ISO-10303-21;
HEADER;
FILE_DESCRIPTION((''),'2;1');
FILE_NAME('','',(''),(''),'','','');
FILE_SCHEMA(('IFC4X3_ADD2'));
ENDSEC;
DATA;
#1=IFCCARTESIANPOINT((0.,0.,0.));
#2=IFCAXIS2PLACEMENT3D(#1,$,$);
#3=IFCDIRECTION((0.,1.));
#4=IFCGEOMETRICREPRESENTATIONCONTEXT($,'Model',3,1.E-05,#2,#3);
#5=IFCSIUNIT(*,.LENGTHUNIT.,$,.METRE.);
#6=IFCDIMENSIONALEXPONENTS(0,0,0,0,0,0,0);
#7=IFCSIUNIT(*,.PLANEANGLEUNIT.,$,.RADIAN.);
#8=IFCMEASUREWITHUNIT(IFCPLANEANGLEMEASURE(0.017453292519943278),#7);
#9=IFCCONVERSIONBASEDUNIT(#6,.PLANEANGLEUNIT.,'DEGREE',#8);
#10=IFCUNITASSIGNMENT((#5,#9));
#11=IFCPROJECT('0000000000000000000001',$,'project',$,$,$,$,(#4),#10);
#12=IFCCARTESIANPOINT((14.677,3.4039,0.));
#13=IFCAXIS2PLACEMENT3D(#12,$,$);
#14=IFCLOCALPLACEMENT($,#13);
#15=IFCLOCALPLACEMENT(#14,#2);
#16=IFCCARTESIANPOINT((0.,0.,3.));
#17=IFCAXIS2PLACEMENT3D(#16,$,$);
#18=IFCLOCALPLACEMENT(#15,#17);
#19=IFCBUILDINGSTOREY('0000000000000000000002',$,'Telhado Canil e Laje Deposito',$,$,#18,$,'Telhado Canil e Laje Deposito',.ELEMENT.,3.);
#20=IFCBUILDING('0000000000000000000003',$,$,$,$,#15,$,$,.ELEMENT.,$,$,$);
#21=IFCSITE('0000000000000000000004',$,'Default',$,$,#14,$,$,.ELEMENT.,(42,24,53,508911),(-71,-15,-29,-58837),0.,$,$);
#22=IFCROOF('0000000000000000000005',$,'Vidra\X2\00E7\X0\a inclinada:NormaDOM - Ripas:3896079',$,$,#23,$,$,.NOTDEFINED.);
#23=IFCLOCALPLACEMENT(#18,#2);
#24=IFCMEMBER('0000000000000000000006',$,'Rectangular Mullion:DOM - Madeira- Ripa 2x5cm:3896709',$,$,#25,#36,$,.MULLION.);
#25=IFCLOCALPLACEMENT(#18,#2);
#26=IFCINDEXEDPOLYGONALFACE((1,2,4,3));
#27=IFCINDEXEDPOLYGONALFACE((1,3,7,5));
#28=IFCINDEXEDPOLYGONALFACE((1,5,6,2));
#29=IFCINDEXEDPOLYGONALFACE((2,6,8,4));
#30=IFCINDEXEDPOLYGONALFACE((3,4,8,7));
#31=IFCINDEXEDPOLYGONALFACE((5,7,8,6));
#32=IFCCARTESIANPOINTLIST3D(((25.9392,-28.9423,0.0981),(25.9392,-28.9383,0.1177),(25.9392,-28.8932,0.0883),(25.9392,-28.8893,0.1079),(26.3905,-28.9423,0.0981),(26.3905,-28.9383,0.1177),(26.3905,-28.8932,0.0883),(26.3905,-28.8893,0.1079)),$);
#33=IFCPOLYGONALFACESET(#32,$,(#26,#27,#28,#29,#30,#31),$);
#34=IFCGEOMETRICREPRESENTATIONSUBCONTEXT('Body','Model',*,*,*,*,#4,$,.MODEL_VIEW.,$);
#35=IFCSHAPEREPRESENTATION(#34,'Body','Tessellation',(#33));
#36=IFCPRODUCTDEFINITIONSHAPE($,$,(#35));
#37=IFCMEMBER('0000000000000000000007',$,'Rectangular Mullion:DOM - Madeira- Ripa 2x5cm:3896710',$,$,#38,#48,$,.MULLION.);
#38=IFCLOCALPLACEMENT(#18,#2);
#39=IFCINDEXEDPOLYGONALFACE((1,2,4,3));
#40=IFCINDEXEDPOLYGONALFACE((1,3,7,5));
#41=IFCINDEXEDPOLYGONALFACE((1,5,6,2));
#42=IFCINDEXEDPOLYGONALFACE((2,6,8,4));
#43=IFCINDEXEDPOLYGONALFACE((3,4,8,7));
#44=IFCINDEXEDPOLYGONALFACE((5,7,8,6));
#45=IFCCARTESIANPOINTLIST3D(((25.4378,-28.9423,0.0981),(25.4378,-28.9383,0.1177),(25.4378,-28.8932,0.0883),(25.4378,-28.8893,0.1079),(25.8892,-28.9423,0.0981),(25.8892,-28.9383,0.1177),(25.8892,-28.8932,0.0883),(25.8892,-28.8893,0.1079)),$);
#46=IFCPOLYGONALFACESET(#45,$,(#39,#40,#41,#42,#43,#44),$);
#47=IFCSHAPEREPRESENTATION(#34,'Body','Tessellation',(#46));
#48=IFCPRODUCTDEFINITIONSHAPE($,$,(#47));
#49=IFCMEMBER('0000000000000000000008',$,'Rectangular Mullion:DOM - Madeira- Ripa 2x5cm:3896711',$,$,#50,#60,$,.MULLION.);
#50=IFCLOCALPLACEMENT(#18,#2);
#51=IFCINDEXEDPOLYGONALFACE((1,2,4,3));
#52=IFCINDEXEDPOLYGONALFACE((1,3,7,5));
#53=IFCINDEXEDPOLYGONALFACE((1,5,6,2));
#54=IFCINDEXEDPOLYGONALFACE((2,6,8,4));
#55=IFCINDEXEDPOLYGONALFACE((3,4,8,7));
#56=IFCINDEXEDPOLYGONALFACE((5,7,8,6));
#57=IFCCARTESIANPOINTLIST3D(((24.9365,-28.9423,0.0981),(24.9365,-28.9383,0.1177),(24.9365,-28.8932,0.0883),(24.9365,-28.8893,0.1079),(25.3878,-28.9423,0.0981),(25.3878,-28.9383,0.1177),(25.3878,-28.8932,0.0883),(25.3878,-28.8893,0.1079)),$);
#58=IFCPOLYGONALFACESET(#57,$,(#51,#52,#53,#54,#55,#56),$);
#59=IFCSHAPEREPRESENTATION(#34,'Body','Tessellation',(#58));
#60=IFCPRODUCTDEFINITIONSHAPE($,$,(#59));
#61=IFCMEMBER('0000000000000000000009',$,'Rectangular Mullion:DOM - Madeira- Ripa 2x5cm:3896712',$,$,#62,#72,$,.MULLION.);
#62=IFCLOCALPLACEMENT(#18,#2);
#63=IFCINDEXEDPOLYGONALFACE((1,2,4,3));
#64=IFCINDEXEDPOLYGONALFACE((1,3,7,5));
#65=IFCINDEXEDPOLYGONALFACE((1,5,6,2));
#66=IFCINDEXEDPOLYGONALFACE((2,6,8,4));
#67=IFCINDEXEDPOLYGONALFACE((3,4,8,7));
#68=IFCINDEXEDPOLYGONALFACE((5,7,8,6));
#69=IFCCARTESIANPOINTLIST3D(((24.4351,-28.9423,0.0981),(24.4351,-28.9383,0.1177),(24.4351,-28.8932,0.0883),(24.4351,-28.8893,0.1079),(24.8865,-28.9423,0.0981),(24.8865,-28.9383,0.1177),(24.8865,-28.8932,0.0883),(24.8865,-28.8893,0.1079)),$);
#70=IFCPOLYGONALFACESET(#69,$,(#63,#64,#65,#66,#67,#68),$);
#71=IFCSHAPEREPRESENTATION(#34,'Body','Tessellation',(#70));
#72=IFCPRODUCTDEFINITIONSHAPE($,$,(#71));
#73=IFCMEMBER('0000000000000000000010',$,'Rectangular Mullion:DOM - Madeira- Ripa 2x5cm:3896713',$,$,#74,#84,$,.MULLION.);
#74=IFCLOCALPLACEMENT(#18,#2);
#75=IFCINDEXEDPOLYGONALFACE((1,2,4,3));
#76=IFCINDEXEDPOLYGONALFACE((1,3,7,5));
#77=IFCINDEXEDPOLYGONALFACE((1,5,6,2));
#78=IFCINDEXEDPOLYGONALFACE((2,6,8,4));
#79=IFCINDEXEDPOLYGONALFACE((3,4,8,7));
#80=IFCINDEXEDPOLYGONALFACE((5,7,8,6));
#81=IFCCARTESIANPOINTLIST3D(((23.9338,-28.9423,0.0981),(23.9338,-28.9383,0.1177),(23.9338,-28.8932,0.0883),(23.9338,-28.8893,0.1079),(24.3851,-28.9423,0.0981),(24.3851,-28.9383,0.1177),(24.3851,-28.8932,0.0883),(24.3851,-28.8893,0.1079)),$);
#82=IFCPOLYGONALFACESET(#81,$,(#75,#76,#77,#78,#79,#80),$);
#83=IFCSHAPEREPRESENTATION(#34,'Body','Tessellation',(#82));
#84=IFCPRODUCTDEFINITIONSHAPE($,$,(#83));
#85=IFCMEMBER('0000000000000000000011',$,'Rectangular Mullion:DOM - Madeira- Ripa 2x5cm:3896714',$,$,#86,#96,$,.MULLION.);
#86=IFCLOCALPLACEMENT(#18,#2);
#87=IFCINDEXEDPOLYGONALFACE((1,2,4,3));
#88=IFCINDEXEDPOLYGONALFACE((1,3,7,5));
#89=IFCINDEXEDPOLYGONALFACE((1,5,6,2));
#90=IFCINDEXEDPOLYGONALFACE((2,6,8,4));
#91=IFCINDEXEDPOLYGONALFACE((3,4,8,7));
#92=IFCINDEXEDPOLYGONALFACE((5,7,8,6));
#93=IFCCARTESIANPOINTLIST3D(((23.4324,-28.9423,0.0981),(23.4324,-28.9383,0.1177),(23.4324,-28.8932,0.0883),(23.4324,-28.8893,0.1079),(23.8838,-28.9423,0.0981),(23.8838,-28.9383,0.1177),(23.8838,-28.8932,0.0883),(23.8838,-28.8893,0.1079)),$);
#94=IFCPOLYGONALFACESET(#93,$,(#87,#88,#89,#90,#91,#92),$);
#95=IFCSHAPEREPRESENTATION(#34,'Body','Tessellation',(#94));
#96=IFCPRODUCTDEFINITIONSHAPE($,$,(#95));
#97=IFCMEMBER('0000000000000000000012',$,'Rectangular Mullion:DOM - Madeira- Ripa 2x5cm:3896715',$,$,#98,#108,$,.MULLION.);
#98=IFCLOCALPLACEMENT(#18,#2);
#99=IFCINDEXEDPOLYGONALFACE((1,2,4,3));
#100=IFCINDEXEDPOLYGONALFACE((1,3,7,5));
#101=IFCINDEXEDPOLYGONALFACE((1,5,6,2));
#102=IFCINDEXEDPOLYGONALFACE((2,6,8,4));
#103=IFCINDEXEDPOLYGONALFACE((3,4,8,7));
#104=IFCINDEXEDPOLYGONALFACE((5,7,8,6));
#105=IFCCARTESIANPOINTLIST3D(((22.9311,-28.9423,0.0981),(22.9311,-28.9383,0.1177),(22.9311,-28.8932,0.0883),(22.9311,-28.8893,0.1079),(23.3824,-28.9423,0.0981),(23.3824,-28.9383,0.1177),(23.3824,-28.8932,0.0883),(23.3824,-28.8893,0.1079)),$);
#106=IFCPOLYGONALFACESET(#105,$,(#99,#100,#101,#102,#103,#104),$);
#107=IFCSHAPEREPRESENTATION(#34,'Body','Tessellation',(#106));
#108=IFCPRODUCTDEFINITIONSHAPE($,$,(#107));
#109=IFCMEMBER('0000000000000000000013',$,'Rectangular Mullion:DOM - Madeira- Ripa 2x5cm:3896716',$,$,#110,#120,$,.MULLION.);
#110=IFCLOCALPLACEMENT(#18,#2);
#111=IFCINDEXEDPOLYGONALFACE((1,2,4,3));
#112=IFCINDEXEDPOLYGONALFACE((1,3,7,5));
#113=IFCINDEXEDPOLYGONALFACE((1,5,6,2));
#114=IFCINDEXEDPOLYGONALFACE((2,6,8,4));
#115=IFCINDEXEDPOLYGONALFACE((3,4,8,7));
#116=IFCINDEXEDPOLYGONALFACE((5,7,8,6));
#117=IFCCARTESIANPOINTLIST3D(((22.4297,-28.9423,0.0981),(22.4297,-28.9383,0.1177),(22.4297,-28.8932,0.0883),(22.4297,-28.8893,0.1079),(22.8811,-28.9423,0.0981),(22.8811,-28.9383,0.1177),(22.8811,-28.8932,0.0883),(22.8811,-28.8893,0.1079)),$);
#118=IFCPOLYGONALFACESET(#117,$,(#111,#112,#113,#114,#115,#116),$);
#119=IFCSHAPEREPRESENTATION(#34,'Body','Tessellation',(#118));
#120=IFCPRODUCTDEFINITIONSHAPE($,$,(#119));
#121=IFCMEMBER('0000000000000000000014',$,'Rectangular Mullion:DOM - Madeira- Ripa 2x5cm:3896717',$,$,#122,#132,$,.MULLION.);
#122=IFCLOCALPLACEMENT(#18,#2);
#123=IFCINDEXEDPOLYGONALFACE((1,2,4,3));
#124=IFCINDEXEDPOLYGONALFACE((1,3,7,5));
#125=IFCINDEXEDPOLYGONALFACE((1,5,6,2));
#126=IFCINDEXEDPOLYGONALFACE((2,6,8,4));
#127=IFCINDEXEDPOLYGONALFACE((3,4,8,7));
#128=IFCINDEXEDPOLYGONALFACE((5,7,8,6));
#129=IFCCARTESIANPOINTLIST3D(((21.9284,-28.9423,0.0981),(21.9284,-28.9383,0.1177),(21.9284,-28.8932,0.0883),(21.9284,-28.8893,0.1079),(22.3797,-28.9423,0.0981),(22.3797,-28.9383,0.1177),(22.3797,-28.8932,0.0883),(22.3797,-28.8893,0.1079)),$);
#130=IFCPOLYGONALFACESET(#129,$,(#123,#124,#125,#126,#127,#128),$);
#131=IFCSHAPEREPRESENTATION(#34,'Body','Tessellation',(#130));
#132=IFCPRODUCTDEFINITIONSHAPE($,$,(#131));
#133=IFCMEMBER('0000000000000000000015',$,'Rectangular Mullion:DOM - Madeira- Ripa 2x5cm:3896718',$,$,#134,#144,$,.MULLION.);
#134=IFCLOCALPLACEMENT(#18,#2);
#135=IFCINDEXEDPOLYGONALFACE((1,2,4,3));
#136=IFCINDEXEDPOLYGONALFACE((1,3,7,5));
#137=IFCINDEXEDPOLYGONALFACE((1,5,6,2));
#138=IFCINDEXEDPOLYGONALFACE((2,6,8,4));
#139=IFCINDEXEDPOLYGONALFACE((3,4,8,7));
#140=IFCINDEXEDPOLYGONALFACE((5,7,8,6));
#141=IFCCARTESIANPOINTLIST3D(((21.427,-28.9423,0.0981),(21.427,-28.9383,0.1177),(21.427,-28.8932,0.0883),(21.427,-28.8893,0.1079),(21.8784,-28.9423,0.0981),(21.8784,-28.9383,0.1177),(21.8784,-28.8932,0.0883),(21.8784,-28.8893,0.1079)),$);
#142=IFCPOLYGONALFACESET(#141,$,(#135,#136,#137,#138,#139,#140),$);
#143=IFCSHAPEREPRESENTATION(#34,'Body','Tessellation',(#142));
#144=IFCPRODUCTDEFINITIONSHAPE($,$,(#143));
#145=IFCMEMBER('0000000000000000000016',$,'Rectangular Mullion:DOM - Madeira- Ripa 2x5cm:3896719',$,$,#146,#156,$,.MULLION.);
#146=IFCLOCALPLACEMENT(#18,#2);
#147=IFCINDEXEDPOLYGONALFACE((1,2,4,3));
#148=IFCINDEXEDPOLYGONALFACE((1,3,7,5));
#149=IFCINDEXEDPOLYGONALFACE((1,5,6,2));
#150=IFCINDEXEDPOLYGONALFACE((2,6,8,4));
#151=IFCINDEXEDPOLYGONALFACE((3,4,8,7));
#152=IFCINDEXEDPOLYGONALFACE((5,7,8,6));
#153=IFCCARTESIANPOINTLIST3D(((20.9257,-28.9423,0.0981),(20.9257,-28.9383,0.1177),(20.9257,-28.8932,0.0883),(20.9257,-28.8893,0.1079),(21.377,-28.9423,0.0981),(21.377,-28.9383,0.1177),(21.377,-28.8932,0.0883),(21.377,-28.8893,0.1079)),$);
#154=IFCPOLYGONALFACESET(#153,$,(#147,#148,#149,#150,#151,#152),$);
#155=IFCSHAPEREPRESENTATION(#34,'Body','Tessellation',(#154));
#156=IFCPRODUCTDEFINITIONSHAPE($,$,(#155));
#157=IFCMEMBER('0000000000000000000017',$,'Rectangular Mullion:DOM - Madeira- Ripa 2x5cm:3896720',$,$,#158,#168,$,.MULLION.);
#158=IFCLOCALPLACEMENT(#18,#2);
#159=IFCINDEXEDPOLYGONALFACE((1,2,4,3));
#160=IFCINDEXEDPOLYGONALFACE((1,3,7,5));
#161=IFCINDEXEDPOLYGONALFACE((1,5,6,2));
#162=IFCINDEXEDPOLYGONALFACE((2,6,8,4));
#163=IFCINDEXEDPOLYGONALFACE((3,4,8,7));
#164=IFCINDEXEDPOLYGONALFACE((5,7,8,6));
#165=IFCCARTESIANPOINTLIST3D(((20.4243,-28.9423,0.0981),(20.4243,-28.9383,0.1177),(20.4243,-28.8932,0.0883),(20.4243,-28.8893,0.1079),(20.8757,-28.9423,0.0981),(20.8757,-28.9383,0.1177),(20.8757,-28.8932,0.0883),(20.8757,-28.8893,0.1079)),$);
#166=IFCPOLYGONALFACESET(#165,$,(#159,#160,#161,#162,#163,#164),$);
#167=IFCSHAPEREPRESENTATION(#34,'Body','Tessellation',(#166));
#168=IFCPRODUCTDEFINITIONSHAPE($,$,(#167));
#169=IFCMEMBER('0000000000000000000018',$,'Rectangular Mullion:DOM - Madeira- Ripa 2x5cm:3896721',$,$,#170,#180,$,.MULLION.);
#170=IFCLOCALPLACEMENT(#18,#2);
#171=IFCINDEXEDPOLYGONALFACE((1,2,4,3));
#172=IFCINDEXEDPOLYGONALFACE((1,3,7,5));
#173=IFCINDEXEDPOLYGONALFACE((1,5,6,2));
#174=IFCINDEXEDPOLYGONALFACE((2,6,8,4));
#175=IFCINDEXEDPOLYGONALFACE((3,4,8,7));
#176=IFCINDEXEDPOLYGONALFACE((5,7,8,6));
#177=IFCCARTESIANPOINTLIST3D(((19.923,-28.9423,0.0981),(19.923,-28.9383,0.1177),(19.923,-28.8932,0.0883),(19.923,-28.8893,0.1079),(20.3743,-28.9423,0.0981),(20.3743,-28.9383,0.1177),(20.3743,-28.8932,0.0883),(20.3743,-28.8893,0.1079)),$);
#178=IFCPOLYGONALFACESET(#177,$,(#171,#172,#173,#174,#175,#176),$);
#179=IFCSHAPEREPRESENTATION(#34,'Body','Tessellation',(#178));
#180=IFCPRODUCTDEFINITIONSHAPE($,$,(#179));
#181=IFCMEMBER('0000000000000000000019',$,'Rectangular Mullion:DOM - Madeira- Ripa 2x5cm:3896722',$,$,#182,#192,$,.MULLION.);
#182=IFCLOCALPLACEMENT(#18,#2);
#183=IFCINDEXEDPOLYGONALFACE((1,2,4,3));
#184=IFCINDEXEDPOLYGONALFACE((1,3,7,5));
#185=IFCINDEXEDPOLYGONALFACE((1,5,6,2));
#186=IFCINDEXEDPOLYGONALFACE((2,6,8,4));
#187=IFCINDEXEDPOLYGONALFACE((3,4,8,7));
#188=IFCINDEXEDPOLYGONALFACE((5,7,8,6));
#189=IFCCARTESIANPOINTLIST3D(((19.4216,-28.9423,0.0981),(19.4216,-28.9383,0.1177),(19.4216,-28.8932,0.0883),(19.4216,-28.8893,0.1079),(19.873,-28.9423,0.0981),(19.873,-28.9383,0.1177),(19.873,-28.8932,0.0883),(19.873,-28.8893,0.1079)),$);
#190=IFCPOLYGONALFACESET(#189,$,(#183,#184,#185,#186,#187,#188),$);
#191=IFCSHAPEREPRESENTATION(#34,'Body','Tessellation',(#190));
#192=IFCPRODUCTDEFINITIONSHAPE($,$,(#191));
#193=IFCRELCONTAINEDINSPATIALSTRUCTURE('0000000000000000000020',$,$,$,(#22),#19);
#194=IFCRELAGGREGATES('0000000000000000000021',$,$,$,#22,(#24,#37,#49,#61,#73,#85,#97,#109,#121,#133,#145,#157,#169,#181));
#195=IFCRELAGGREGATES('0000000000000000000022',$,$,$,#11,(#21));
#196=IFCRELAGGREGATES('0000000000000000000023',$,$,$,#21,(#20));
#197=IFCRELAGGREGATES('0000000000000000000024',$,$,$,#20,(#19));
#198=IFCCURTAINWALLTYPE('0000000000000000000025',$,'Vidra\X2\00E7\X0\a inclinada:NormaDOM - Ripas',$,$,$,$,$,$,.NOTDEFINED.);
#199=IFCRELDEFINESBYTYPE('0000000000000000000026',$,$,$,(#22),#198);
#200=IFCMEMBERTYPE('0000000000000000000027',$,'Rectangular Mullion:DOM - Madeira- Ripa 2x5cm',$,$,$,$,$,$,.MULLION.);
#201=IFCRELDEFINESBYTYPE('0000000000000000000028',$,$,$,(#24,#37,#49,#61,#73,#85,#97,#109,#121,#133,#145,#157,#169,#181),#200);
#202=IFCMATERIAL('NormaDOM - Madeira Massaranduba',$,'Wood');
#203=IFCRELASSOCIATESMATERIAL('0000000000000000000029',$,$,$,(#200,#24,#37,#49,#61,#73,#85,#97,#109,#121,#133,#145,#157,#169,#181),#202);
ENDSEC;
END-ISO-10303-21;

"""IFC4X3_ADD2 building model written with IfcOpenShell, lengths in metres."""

from ifc_helpers import new_model, entity, si_unit, converted_unit, direction, frame, origin, origin_2d_with_axis, place, context, subcontext, project, spatial, rectangle, extrude, source, transform, mapped, material, material_profile, profile_set, profile_usage, type_object, type_shapes, element, aggregate, save


model = new_model("IFC4X3_ADD2")

# Units and contexts
model_context = context("Model", 3, precision=1e-05, world=origin(), true_north=direction((0.0, 1.0)))
body_context = subcontext(model_context, "Body", "Model", "MODEL_VIEW")
ifc_project = project(units=[si_unit("LENGTHUNIT", "METRE"), converted_unit("PLANEANGLEUNIT", "DEGREE", entity("IfcPlaneAngleMeasure", 0.017453292519943278), si_unit("PLANEANGLEUNIT", "RADIAN"), dimensions=[0, 0, 0, 0, 0, 0, 0])], contexts=[model_context])

# Site, building, storey
site_placement = place(None, frame((14.677, 3.4039, 0.0)))
site = spatial("IfcSite", under=ifc_project, at=site_placement, Name="Default", CompositionType="ELEMENT", RefLatitude=(42, 24, 53, 508911), RefLongitude=(-71, -15, -29, -58837), RefElevation=0.0)
building_placement = place(site_placement, origin())
building = spatial("IfcBuilding", under=site, at=building_placement, CompositionType="ELEMENT")
storey_placement = place(building_placement, frame((0.0, 0.0, 3.0)))
storey = spatial("IfcBuildingStorey", under=building, at=storey_placement, Name="Telhado Canil e Laje Deposito", LongName="Telhado Canil e Laje Deposito", CompositionType="ELEMENT", Elevation=3.0)

# Roof, members
curtain_wall_type = type_object("IfcCurtainWallType", Name="Vidraça inclinada:NormaDOM - Ripas", PredefinedType="NOTDEFINED")
roof_placement = place(storey_placement, frame((0.0, 0.0, -3.0)))
roof = element("IfcRoof", 1, at=roof_placement, inside=storey, type_object=curtain_wall_type, Name="Vidraça inclinada:NormaDOM - Ripas:3896079", PredefinedType="NOTDEFINED")
ifc_material = material(Name="NormaDOM - Madeira Massaranduba", Category="Wood")
ifc_material_profile_1 = material_profile(ifc_material, rectangle(XDim=0.05, YDim=0.02, at=origin_2d_with_axis()), Name="DOM - Madeira- Ripa 2x5cm")
ifc_profile_set_1 = profile_set([ifc_material_profile_1], Name="DOM - Madeira- Ripa 2x5cm")
ifc_profile_usage_1 = profile_usage(ifc_profile_set_1)
member_type_1 = type_object("IfcMemberType", Name="Rectangular Mullion:DOM - Madeira- Ripa 2x5cm", PredefinedType="MULLION", material=ifc_profile_set_1)
shared_shape_1 = source(origin(), body_context, "Body", "SweptSolid", [
    extrude(rectangle(XDim=0.05, YDim=0.02, at=origin_2d_with_axis()), frame((0.025, 0.01, -0.4514), z_axis=(0.0, 0.0, 1.0), x_axis=(-1.0, 0.0, 0.0)), (0.0, 0.0, 1.0), 0.4514),
])
type_shapes(member_type_1, [shared_shape_1])
member_1_placement = place(roof_placement, frame((26.3905, -28.8893, 3.1079), z_axis=(1.0, 0.0, 0.0), x_axis=(0.0, -0.980581, 0.196116)))
member_1 = element("IfcMember", 2, at=member_1_placement, type_object=member_type_1, material=ifc_profile_usage_1, Name="Rectangular Mullion:DOM - Madeira- Ripa 2x5cm:3896709", PredefinedType="MULLION", context=body_context, shape_type="MappedRepresentation", body=[
    mapped(shared_shape_1, transform((0.0, 0.0, 0.0), scale=1.0)),
])
member_2_placement = place(roof_placement, frame((25.8892, -28.8893, 3.1079), z_axis=(1.0, 0.0, 0.0), x_axis=(0.0, -0.980581, 0.196116)))
member_2 = element("IfcMember", 3, at=member_2_placement, type_object=member_type_1, material=ifc_profile_usage_1, Name="Rectangular Mullion:DOM - Madeira- Ripa 2x5cm:3896710", PredefinedType="MULLION", context=body_context, shape_type="MappedRepresentation", body=[
    mapped(shared_shape_1, transform((0.0, 0.0, 0.0), scale=1.0)),
])
member_3_placement = place(roof_placement, frame((25.3878, -28.8893, 3.1079), z_axis=(1.0, 0.0, 0.0), x_axis=(0.0, -0.980581, 0.196116)))
member_3 = element("IfcMember", 4, at=member_3_placement, type_object=member_type_1, material=ifc_profile_usage_1, Name="Rectangular Mullion:DOM - Madeira- Ripa 2x5cm:3896711", PredefinedType="MULLION", context=body_context, shape_type="MappedRepresentation", body=[
    mapped(shared_shape_1, transform((0.0, 0.0, 0.0), scale=1.0)),
])
member_4_placement = place(roof_placement, frame((24.8865, -28.8893, 3.1079), z_axis=(1.0, 0.0, 0.0), x_axis=(0.0, -0.980581, 0.196116)))
member_4 = element("IfcMember", 5, at=member_4_placement, type_object=member_type_1, material=ifc_profile_usage_1, Name="Rectangular Mullion:DOM - Madeira- Ripa 2x5cm:3896712", PredefinedType="MULLION", context=body_context, shape_type="MappedRepresentation", body=[
    mapped(shared_shape_1, transform((0.0, 0.0, 0.0), scale=1.0)),
])
member_5_placement = place(roof_placement, frame((24.3851, -28.8893, 3.1079), z_axis=(1.0, 0.0, 0.0), x_axis=(0.0, -0.980581, 0.196116)))
member_5 = element("IfcMember", 6, at=member_5_placement, type_object=member_type_1, material=ifc_profile_usage_1, Name="Rectangular Mullion:DOM - Madeira- Ripa 2x5cm:3896713", PredefinedType="MULLION", context=body_context, shape_type="MappedRepresentation", body=[
    mapped(shared_shape_1, transform((0.0, 0.0, 0.0), scale=1.0)),
])
member_6_placement = place(roof_placement, frame((23.8838, -28.8893, 3.1079), z_axis=(1.0, 0.0, 0.0), x_axis=(0.0, -0.980581, 0.196116)))
member_6 = element("IfcMember", 7, at=member_6_placement, type_object=member_type_1, material=ifc_profile_usage_1, Name="Rectangular Mullion:DOM - Madeira- Ripa 2x5cm:3896714", PredefinedType="MULLION", context=body_context, shape_type="MappedRepresentation", body=[
    mapped(shared_shape_1, transform((0.0, 0.0, 0.0), scale=1.0)),
])
member_7_placement = place(roof_placement, frame((23.3824, -28.8893, 3.1079), z_axis=(1.0, 0.0, 0.0), x_axis=(0.0, -0.980581, 0.196116)))
member_7 = element("IfcMember", 8, at=member_7_placement, type_object=member_type_1, material=ifc_profile_usage_1, Name="Rectangular Mullion:DOM - Madeira- Ripa 2x5cm:3896715", PredefinedType="MULLION", context=body_context, shape_type="MappedRepresentation", body=[
    mapped(shared_shape_1, transform((0.0, 0.0, 0.0), scale=1.0)),
])
member_8_placement = place(roof_placement, frame((22.8811, -28.8893, 3.1079), z_axis=(1.0, 0.0, 0.0), x_axis=(0.0, -0.980581, 0.196116)))
member_8 = element("IfcMember", 9, at=member_8_placement, type_object=member_type_1, material=ifc_profile_usage_1, Name="Rectangular Mullion:DOM - Madeira- Ripa 2x5cm:3896716", PredefinedType="MULLION", context=body_context, shape_type="MappedRepresentation", body=[
    mapped(shared_shape_1, transform((0.0, 0.0, 0.0), scale=1.0)),
])
member_9_placement = place(roof_placement, frame((22.3797, -28.8893, 3.1079), z_axis=(1.0, 0.0, 0.0), x_axis=(0.0, -0.980581, 0.196116)))
member_9 = element("IfcMember", 10, at=member_9_placement, type_object=member_type_1, material=ifc_profile_usage_1, Name="Rectangular Mullion:DOM - Madeira- Ripa 2x5cm:3896717", PredefinedType="MULLION", context=body_context, shape_type="MappedRepresentation", body=[
    mapped(shared_shape_1, transform((0.0, 0.0, 0.0), scale=1.0)),
])
member_10_placement = place(roof_placement, frame((21.8784, -28.8893, 3.1079), z_axis=(1.0, 0.0, 0.0), x_axis=(0.0, -0.980581, 0.196116)))
member_10 = element("IfcMember", 11, at=member_10_placement, type_object=member_type_1, material=ifc_profile_usage_1, Name="Rectangular Mullion:DOM - Madeira- Ripa 2x5cm:3896718", PredefinedType="MULLION", context=body_context, shape_type="MappedRepresentation", body=[
    mapped(shared_shape_1, transform((0.0, 0.0, 0.0), scale=1.0)),
])
member_11_placement = place(roof_placement, frame((21.377, -28.8893, 3.1079), z_axis=(1.0, 0.0, 0.0), x_axis=(0.0, -0.980581, 0.196116)))
member_11 = element("IfcMember", 12, at=member_11_placement, type_object=member_type_1, material=ifc_profile_usage_1, Name="Rectangular Mullion:DOM - Madeira- Ripa 2x5cm:3896719", PredefinedType="MULLION", context=body_context, shape_type="MappedRepresentation", body=[
    mapped(shared_shape_1, transform((0.0, 0.0, 0.0), scale=1.0)),
])
member_12_placement = place(roof_placement, frame((20.8757, -28.8893, 3.1079), z_axis=(1.0, 0.0, 0.0), x_axis=(0.0, -0.980581, 0.196116)))
member_12 = element("IfcMember", 13, at=member_12_placement, type_object=member_type_1, material=ifc_profile_usage_1, Name="Rectangular Mullion:DOM - Madeira- Ripa 2x5cm:3896720", PredefinedType="MULLION", context=body_context, shape_type="MappedRepresentation", body=[
    mapped(shared_shape_1, transform((0.0, 0.0, 0.0), scale=1.0)),
])
member_13_placement = place(roof_placement, frame((20.3743, -28.8893, 3.1079), z_axis=(1.0, 0.0, 0.0), x_axis=(0.0, -0.980581, 0.196116)))
member_13 = element("IfcMember", 14, at=member_13_placement, type_object=member_type_1, material=ifc_profile_usage_1, Name="Rectangular Mullion:DOM - Madeira- Ripa 2x5cm:3896721", PredefinedType="MULLION", context=body_context, shape_type="MappedRepresentation", body=[
    mapped(shared_shape_1, transform((0.0, 0.0, 0.0), scale=1.0)),
])
member_14_placement = place(roof_placement, frame((19.873, -28.8893, 3.1079), z_axis=(1.0, 0.0, 0.0), x_axis=(0.0, -0.980581, 0.196116)))
member_14 = element("IfcMember", 15, at=member_14_placement, type_object=member_type_1, material=ifc_profile_usage_1, Name="Rectangular Mullion:DOM - Madeira- Ripa 2x5cm:3896722", PredefinedType="MULLION", context=body_context, shape_type="MappedRepresentation", body=[
    mapped(shared_shape_1, transform((0.0, 0.0, 0.0), scale=1.0)),
])
aggregate(roof, [member_1, member_2, member_3, member_4, member_5, member_6, member_7, member_8, member_9, member_10, member_11, member_12, member_13, member_14])

save(model, "model.ifc")
